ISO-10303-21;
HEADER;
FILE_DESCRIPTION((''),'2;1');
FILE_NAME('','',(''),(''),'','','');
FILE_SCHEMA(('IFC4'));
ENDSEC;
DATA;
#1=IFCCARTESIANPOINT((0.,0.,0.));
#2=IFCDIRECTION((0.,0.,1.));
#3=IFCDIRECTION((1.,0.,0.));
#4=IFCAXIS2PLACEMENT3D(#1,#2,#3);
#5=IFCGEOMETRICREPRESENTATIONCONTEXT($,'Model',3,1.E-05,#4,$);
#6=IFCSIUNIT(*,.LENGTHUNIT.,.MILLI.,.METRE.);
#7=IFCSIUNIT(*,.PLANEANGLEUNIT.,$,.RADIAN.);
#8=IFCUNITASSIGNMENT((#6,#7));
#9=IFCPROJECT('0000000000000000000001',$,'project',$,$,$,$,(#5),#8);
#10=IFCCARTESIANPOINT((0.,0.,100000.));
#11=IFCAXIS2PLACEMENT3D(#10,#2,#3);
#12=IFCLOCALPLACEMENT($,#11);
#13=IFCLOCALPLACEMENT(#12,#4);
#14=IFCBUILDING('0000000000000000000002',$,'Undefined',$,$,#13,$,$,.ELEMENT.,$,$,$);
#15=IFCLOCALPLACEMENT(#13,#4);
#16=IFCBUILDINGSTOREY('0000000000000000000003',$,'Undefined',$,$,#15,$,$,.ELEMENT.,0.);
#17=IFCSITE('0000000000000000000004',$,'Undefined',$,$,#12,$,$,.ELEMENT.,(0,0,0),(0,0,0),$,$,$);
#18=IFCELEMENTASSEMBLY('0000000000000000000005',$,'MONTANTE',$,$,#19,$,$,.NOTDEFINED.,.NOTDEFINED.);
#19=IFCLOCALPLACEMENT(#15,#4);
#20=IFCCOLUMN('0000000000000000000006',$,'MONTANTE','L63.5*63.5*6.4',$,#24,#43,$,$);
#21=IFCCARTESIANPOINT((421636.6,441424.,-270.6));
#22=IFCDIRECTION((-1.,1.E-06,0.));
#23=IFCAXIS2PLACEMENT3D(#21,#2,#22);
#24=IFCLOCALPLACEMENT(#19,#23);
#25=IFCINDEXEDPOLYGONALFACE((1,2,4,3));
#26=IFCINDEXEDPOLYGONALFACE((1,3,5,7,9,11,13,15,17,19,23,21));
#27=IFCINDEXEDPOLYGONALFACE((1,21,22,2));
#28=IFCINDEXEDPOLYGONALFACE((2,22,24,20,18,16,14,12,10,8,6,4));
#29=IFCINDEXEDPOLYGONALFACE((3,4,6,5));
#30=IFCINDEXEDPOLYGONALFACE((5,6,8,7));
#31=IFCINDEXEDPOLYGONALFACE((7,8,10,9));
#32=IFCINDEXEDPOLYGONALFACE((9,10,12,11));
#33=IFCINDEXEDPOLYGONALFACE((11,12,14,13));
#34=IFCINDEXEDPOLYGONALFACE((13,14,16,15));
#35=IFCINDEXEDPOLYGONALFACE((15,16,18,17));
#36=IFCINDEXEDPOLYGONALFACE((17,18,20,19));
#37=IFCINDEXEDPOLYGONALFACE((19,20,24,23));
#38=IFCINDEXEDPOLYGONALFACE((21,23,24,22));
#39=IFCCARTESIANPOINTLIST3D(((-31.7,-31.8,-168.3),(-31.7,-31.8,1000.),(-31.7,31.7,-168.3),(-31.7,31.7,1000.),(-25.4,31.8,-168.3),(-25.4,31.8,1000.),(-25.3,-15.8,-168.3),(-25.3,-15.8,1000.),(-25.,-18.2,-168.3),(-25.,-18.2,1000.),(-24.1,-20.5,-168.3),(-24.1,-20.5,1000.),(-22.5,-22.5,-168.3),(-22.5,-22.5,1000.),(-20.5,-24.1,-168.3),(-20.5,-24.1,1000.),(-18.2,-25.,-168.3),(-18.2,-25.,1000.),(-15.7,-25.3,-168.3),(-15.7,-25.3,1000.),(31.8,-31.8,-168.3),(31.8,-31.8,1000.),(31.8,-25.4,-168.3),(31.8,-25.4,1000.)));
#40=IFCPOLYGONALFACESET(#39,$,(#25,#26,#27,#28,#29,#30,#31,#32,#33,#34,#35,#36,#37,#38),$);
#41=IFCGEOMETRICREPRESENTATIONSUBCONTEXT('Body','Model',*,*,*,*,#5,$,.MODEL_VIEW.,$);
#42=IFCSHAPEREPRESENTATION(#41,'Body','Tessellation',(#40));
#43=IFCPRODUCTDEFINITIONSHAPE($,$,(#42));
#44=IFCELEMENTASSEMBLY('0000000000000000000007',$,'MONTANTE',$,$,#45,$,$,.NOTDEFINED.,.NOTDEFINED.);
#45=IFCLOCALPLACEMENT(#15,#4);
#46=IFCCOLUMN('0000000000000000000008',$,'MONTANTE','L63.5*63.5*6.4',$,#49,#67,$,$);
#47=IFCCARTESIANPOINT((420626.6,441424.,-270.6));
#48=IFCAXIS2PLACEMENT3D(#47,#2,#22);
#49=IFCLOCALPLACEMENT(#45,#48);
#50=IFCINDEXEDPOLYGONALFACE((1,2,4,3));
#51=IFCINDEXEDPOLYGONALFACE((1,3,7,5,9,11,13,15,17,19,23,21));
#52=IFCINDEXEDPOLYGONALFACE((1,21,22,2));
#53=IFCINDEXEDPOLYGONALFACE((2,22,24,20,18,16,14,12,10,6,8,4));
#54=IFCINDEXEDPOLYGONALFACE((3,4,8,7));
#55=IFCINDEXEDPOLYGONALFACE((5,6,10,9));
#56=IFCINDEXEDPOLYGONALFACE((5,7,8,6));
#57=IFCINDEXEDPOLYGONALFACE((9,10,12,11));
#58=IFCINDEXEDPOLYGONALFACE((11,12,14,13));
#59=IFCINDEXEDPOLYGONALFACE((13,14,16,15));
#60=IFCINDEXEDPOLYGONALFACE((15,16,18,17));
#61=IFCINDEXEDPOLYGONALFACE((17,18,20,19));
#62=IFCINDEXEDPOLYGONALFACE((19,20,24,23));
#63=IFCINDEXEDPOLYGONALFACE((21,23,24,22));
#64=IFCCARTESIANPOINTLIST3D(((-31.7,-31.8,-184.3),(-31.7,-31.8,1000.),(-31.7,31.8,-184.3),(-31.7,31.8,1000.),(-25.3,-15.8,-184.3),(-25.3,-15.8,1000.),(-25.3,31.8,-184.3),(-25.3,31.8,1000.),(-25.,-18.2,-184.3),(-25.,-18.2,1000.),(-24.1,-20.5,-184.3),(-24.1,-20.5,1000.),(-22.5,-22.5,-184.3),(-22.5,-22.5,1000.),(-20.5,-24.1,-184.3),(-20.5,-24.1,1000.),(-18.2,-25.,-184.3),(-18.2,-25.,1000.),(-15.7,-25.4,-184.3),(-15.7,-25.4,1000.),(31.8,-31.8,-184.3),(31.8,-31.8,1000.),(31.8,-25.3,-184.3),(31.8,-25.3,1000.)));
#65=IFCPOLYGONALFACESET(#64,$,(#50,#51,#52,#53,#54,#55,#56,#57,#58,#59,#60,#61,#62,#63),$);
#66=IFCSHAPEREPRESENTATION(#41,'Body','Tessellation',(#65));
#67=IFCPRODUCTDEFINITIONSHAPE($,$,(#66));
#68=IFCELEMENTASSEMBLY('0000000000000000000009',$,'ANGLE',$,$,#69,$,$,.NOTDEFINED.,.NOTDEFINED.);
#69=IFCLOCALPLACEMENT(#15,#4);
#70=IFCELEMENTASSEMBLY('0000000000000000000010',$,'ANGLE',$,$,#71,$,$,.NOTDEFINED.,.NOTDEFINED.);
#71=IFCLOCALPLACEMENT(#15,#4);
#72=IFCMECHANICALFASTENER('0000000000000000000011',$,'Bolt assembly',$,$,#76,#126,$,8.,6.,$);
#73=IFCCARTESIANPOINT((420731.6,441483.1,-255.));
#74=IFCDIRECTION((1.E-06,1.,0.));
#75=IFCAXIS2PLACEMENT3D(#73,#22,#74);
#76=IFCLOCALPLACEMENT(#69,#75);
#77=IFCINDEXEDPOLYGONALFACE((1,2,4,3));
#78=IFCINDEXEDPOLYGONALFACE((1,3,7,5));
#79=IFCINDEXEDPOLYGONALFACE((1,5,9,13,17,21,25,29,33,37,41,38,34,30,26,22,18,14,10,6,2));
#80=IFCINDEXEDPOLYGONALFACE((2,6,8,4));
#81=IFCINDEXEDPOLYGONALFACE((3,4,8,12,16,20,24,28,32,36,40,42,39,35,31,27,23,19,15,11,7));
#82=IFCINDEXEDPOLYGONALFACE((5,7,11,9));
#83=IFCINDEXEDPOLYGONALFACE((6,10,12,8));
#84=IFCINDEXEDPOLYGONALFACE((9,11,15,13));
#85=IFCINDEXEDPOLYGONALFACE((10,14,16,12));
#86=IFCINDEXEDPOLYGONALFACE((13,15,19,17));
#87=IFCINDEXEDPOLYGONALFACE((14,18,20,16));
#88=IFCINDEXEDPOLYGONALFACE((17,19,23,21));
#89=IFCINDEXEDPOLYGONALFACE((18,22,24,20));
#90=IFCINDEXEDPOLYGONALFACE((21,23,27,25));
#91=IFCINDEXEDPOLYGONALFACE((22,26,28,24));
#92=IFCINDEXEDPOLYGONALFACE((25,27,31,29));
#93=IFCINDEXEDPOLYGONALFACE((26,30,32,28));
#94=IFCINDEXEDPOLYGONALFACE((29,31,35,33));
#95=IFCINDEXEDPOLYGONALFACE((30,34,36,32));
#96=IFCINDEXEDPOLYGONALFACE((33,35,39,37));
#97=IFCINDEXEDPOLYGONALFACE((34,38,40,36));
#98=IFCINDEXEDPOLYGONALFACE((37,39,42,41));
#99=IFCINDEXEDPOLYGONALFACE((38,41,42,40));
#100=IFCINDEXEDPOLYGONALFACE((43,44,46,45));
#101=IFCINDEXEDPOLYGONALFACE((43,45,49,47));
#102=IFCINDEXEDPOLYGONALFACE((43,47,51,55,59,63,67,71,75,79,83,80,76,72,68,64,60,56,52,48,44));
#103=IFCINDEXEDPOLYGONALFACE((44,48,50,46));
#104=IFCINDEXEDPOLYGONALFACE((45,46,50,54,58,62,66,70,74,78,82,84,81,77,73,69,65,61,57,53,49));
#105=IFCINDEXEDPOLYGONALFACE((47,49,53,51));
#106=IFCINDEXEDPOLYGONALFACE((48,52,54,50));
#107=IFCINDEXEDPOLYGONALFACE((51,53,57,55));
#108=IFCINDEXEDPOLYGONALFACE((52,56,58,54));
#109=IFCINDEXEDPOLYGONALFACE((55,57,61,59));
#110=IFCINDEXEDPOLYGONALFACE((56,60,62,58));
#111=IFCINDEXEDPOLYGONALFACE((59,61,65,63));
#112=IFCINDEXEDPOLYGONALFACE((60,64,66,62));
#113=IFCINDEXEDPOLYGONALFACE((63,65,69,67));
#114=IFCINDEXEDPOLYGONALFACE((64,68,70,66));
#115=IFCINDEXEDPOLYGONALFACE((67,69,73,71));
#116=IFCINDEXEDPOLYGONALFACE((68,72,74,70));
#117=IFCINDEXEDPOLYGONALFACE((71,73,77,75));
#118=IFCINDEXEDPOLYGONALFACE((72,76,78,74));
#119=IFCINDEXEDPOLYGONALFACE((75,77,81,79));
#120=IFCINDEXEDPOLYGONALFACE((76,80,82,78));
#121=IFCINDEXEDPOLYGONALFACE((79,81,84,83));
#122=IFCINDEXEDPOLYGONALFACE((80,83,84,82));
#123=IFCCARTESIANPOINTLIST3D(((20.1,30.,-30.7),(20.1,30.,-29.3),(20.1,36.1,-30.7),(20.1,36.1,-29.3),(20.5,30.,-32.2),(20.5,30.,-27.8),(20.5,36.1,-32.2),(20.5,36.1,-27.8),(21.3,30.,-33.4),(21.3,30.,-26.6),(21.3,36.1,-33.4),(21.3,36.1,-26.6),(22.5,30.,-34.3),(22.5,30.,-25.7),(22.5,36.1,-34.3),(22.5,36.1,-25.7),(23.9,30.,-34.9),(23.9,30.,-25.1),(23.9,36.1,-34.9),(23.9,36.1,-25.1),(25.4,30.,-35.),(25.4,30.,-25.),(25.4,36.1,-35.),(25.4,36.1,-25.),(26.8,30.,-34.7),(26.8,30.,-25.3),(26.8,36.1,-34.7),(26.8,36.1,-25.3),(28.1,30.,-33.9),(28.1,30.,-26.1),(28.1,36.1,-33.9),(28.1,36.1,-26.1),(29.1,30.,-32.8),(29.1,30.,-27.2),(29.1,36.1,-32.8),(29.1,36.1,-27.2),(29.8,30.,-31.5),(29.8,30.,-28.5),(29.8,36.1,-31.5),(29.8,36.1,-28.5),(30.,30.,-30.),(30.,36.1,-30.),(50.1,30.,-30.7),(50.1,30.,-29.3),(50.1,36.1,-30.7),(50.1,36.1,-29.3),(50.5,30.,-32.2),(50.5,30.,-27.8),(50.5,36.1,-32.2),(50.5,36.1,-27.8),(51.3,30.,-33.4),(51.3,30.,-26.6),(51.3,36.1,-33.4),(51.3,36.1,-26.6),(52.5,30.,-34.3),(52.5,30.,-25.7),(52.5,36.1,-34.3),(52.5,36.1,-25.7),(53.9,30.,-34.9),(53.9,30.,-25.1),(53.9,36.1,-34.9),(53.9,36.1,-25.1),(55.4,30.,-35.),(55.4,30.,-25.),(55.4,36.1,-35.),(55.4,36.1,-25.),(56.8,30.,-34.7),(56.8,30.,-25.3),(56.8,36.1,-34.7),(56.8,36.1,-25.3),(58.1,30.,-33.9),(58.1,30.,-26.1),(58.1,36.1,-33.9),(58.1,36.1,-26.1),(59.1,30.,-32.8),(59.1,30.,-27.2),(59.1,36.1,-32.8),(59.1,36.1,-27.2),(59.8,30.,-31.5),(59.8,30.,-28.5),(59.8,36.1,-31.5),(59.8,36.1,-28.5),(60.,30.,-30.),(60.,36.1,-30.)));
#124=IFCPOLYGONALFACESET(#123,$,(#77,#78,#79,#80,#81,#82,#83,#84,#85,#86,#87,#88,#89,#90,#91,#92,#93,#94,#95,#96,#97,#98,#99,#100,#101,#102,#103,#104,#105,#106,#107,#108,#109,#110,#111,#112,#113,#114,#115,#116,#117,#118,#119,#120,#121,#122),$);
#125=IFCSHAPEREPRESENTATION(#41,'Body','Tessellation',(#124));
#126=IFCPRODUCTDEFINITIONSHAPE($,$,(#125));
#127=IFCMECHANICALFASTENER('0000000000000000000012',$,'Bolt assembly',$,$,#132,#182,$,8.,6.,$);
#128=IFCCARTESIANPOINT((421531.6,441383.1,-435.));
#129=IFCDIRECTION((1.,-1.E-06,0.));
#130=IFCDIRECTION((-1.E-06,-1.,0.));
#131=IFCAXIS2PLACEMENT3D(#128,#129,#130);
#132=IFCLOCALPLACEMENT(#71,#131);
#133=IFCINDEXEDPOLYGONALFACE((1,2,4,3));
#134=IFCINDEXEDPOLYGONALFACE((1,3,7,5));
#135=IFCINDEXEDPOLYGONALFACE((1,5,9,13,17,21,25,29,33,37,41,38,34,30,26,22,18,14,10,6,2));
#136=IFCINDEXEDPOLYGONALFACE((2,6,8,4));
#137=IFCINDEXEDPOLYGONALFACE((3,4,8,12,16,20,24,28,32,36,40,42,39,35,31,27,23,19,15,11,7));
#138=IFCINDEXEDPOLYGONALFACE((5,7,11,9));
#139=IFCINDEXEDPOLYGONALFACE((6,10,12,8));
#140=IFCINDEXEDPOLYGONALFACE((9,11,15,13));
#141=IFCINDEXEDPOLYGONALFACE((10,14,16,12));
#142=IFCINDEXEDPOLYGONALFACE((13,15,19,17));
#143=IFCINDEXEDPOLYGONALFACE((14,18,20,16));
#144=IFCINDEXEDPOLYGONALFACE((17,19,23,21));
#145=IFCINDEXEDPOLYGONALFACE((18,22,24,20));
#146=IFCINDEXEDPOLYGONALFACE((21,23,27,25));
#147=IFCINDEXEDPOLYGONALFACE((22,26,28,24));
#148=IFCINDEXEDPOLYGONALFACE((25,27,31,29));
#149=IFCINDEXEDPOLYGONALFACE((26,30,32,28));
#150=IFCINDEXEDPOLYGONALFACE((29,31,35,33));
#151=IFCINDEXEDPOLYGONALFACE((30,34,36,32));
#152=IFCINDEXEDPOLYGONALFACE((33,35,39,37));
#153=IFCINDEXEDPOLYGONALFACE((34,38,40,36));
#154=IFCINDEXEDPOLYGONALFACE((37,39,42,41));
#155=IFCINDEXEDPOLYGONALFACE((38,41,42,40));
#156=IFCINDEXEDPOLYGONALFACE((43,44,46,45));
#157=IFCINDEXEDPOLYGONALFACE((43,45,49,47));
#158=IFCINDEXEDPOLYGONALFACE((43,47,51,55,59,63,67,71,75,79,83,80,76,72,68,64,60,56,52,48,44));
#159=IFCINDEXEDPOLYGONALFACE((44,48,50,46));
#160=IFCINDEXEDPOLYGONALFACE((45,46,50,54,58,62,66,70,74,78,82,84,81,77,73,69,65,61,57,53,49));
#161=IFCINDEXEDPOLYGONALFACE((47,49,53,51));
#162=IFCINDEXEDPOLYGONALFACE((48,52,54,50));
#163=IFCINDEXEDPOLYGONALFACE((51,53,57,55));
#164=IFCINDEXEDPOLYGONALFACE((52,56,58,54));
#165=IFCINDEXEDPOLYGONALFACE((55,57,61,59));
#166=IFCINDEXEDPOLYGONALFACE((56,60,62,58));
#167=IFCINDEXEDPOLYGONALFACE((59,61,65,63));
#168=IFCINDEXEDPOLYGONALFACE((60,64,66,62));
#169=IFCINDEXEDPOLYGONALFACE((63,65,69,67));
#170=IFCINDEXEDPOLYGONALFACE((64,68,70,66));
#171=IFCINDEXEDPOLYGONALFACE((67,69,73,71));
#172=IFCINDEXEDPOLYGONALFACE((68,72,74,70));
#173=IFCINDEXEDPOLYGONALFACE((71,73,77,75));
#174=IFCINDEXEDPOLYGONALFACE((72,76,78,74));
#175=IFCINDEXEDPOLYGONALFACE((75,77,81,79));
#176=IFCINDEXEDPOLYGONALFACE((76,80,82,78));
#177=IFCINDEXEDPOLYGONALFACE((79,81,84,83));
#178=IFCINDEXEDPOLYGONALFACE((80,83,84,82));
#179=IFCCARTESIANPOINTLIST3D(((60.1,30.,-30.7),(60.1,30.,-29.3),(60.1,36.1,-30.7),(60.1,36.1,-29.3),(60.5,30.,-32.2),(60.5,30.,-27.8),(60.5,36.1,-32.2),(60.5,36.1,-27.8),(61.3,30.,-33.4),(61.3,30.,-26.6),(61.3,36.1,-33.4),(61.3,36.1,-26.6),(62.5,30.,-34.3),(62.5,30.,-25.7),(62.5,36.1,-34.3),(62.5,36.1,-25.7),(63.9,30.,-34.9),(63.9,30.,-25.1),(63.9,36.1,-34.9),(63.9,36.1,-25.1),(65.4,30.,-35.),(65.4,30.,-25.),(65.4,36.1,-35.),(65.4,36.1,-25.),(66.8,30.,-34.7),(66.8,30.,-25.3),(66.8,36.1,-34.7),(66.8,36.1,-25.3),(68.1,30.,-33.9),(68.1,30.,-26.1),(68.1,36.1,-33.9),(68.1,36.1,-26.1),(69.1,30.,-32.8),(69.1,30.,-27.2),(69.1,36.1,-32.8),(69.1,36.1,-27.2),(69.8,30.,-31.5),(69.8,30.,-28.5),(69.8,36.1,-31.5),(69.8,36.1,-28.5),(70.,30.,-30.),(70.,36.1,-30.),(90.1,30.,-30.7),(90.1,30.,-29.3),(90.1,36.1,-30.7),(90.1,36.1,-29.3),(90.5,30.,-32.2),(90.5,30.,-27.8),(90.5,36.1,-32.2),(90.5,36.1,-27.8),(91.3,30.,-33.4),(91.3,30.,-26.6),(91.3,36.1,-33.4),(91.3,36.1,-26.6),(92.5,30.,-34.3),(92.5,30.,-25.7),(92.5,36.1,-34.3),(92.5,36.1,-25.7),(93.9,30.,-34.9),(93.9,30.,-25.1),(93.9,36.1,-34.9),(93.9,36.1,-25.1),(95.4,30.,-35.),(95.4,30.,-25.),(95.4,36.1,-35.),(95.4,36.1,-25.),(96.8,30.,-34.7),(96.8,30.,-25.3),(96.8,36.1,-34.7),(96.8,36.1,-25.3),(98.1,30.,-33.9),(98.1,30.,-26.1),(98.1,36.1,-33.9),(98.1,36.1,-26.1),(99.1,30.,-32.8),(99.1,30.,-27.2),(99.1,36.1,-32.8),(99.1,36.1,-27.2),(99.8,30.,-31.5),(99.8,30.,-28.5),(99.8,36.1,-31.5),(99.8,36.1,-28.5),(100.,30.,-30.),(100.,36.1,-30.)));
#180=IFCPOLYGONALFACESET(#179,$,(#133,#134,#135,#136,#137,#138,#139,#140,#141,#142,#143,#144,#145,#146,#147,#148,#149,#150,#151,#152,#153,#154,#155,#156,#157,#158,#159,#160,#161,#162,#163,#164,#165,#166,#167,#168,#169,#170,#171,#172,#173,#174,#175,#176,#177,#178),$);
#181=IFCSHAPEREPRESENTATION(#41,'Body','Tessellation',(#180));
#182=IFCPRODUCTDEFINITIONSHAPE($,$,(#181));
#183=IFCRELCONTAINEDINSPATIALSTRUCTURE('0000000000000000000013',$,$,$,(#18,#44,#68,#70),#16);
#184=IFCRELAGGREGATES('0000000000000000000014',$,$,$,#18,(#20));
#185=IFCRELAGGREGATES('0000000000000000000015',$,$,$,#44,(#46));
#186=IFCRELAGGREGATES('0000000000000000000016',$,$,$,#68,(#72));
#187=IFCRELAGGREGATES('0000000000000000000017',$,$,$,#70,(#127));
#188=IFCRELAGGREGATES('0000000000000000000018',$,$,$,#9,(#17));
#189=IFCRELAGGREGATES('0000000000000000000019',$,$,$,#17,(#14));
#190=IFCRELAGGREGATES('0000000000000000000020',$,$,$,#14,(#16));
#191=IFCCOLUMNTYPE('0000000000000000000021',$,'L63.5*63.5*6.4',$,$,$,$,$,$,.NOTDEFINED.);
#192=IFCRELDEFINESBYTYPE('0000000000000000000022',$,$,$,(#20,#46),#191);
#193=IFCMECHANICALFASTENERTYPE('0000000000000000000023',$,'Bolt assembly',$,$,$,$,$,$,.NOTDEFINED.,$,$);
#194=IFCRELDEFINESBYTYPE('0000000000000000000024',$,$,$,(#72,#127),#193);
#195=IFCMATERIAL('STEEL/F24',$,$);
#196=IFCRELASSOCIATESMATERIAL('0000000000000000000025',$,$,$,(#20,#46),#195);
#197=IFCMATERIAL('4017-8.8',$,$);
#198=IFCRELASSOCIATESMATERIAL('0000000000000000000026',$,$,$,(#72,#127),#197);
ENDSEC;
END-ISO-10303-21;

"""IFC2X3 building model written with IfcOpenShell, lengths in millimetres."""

from ifc_helpers import new_model, si_unit, frame, origin_with_axes, origin_2d_with_axis, place, context, subcontext, project, spatial, circle, l_section, extrude, clip, halfspace, source, transform, mapped, material, type_object, element, aggregate, save


model = new_model("IFC2X3")

# Units and contexts
model_context = context("Model", 3, precision=1e-05, world=origin_with_axes())
body_context = subcontext(model_context, "Body", "Model", "MODEL_VIEW")
ifc_project = project(units=[si_unit("LENGTHUNIT", "METRE", prefix="MILLI"), si_unit("PLANEANGLEUNIT", "RADIAN")], contexts=[model_context])

# Site, building, storey
site_placement = place(None, frame((0.0, 0.0, 100000.0), z_axis=(0.0, 0.0, 1.0), x_axis=(1.0, 0.0, 0.0)))
site = spatial("IfcSite", under=ifc_project, at=site_placement, Name="Undefined", CompositionType="ELEMENT", RefLatitude=(0, 0, 0), RefLongitude=(0, 0, 0))
building_placement = place(site_placement, origin_with_axes())
building = spatial("IfcBuilding", under=site, at=building_placement, Name="Undefined", CompositionType="ELEMENT")
storey_placement = place(building_placement, origin_with_axes())
storey = spatial("IfcBuildingStorey", under=building, at=storey_placement, Name="Undefined", CompositionType="ELEMENT", Elevation=0.0)

# Element assemblies, columns
assembly_1_placement = place(storey_placement, origin_with_axes())
assembly_1 = element("IfcElementAssembly", 1, at=assembly_1_placement, inside=storey, Name="MONTANTE", AssemblyPlace="NOTDEFINED", PredefinedType="NOTDEFINED")
ifc_material_1 = material(Name="STEEL/F24")
column_type = type_object("IfcColumnType", Name="L63.5*63.5*6.4", PredefinedType="NOTDEFINED")
column_1_placement = place(assembly_1_placement, frame((421636.6, 441424.0, -270.6), z_axis=(0.0, 0.0, 1.0), x_axis=(-1.0, 0.000001, 0.0)))
column_1 = element("IfcColumn", 2, at=column_1_placement, type_object=column_type, material=ifc_material_1, Name="MONTANTE", Description="L63.5*63.5*6.4", context=body_context, shape_type="Clipping", body=[
    clip(extrude(l_section(Depth=63.5, Width=63.5, Thickness=6.4, FilletRadius=9.6, at=origin_2d_with_axis()), frame((0.0, 0.0, 1000.0), z_axis=(0.0, 0.0, -1.0), x_axis=(0.0, 1.0, 0.0)), (0.0, 0.0, 1.0), 1168.3), halfspace(frame((0.0, 0.0, -168.3), z_axis=(0.0, 0.0, -1.0), x_axis=(0.0, -1.0, 0.0)), False)),
])
assembly_2_placement = place(storey_placement, origin_with_axes())
assembly_2 = element("IfcElementAssembly", 3, at=assembly_2_placement, inside=storey, Name="MONTANTE", AssemblyPlace="NOTDEFINED", PredefinedType="NOTDEFINED")
column_2_placement = place(assembly_2_placement, frame((420626.6, 441424.0, -270.6), z_axis=(0.0, 0.0, 1.0), x_axis=(-1.0, 0.000001, 0.0)))
column_2 = element("IfcColumn", 4, at=column_2_placement, type_object=column_type, material=ifc_material_1, Name="MONTANTE", Description="L63.5*63.5*6.4", context=body_context, shape_type="Clipping", body=[
    clip(extrude(l_section(Depth=63.5, Width=63.5, Thickness=6.4, FilletRadius=9.6, at=origin_2d_with_axis()), frame((0.0, 0.0, 1000.0), z_axis=(0.0, 0.0, -1.0), x_axis=(0.0, 1.0, 0.0)), (0.0, 0.0, 1.0), 1184.3), halfspace(frame((0.0, 0.0, -184.3), z_axis=(0.0, 0.0, -1.0), x_axis=(0.0, 1.0, 0.0)), False)),
])

# Element assemblies
assembly_3_placement = place(storey_placement, origin_with_axes())
assembly_3 = element("IfcElementAssembly", 5, at=assembly_3_placement, inside=storey, Name="ANGLE", AssemblyPlace="NOTDEFINED", PredefinedType="NOTDEFINED")
assembly_4_placement = place(storey_placement, origin_with_axes())
assembly_4 = element("IfcElementAssembly", 6, at=assembly_4_placement, inside=storey, Name="ANGLE", AssemblyPlace="NOTDEFINED", PredefinedType="NOTDEFINED")

# Mechanical fasteners
ifc_material_2 = material(Name="4017-8.8")
mechanical_fastener_type = type_object("IfcMechanicalFastenerType", Name="Bolt assembly")
aggregate(assembly_1, [column_1])
aggregate(assembly_2, [column_2])
shared_shape_1 = source(origin_with_axes(), body_context, "Body", "SweptSolid", [
    extrude(circle(Radius=5.0, at=origin_2d_with_axis()), frame((0.0, 30.0, 0.0), z_axis=(0.0, 1.0, 0.0), x_axis=(1.0, 0.0, 0.0)), (0.0, 0.0, 1.0), 6.1),
])
mechanical_fastener_1_placement = place(assembly_3_placement, frame((420731.6, 441483.1, -255.0), z_axis=(-1.0, 0.000001, 0.0), x_axis=(0.000001, 1.0, 0.0)))
mechanical_fastener_1 = element("IfcMechanicalFastener", 7, at=mechanical_fastener_1_placement, type_object=mechanical_fastener_type, material=ifc_material_2, Name="Bolt assembly", NominalDiameter=8.0, NominalLength=6.0, context=body_context, shape_type="MappedRepresentation", body=[
    mapped(shared_shape_1, transform((25.0, 0.0, -30.0))),
    mapped(shared_shape_1, transform((55.0, 0.0, -30.0))),
])
aggregate(assembly_3, [mechanical_fastener_1])
mechanical_fastener_2_placement = place(assembly_4_placement, frame((421531.6, 441383.1, -435.0), z_axis=(1.0, -0.000001, 0.0), x_axis=(-0.000001, -1.0, 0.0)))
mechanical_fastener_2 = element("IfcMechanicalFastener", 8, at=mechanical_fastener_2_placement, type_object=mechanical_fastener_type, material=ifc_material_2, Name="Bolt assembly", NominalDiameter=8.0, NominalLength=6.0, context=body_context, shape_type="MappedRepresentation", body=[
    mapped(shared_shape_1, transform((95.0, 0.0, -30.0))),
    mapped(shared_shape_1, transform((65.0, 0.0, -30.0))),
])
aggregate(assembly_4, [mechanical_fastener_2])

save(model, "model.ifc")
